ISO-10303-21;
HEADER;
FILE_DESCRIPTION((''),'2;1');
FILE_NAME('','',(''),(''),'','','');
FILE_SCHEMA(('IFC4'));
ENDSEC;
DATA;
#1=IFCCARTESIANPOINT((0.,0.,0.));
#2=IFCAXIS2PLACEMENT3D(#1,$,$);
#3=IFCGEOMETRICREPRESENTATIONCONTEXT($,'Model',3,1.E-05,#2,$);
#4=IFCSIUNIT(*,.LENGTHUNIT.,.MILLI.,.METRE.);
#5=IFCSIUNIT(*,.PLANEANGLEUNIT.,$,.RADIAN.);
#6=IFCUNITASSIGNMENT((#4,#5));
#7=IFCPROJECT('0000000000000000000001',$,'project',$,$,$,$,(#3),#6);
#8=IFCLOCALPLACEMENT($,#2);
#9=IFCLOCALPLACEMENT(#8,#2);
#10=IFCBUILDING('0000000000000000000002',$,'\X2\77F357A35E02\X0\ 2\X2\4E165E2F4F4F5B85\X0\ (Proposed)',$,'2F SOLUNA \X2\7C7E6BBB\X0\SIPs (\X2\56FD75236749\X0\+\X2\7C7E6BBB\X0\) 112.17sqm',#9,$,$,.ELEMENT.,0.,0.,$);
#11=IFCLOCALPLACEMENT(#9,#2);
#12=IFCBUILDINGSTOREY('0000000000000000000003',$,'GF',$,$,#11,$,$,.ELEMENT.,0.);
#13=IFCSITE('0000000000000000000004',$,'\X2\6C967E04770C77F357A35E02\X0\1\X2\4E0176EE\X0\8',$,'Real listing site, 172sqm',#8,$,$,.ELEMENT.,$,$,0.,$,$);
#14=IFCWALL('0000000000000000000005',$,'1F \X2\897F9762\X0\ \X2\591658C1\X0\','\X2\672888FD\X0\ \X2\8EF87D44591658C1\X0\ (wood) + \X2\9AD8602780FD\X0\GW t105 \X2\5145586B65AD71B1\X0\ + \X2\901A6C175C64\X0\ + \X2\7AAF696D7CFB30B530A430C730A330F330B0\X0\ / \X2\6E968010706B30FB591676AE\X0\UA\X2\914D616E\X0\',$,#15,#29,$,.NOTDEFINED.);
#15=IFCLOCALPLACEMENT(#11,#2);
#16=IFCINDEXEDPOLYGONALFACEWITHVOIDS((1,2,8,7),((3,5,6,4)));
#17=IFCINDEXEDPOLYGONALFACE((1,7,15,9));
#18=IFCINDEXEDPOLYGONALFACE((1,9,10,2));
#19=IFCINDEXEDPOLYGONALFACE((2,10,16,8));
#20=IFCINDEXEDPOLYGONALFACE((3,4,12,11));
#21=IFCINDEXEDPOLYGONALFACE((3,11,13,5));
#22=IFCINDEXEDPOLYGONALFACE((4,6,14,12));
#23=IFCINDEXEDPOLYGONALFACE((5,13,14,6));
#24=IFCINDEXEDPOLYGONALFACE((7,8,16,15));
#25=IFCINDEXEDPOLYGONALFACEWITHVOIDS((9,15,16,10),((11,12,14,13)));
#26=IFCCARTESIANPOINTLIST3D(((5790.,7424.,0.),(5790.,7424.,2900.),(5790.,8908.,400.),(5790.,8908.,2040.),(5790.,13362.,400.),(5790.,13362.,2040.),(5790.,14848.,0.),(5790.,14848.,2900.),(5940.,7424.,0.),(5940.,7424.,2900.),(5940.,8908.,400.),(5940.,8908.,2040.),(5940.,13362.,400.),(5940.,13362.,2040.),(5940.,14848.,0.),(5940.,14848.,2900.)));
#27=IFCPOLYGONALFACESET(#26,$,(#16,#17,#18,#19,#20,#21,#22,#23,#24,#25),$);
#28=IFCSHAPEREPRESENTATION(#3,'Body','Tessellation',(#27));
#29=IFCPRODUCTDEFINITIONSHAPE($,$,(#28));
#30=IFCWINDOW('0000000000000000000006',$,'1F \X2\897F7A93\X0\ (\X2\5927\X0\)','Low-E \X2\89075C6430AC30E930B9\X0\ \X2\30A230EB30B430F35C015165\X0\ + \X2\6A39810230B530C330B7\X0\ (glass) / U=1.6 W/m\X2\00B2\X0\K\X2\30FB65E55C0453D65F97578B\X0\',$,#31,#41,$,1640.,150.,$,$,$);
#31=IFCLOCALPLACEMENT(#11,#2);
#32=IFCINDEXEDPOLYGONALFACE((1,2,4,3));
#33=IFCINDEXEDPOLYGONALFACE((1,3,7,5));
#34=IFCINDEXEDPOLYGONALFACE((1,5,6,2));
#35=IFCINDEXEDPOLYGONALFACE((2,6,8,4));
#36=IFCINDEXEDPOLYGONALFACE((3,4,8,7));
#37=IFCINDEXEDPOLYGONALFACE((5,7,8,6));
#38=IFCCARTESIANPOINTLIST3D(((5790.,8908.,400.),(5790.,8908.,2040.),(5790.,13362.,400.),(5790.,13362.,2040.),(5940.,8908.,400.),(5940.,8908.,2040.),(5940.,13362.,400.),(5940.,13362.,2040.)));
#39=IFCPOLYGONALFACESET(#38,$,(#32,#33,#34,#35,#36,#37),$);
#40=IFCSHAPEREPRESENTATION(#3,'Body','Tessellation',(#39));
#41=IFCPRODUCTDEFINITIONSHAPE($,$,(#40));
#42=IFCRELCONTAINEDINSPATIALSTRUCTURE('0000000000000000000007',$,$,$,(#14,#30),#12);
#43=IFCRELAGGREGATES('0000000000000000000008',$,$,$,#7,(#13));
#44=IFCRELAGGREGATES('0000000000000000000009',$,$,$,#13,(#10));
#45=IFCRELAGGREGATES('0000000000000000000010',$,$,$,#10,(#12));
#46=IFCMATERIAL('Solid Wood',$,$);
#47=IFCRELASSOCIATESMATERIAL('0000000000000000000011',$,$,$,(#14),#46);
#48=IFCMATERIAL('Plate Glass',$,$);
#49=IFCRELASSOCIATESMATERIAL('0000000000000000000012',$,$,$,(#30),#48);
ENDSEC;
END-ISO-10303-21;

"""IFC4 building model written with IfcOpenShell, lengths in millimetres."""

from ifc_helpers import new_model, si_unit, frame, frame_2d, origin, place, context, project, spatial, rectangle, extrude, material, element, fill, save


model = new_model("IFC4")

# Units and contexts
model_context = context("Model", 3, precision=1e-05, world=origin())
ifc_project = project(units=[si_unit("LENGTHUNIT", "METRE", prefix="MILLI"), si_unit("PLANEANGLEUNIT", "RADIAN")], contexts=[model_context])

# Site, building, storey
site_placement = place(None, origin())
site = spatial("IfcSite", under=ifc_project, at=site_placement, Name="沖縄県石垣市1丁目8", ObjectType="Real listing site, 172sqm", CompositionType="ELEMENT", RefElevation=0.0)
building_placement = place(site_placement, origin())
building = spatial("IfcBuilding", under=site, at=building_placement, Name="石垣市 2世帯住宅 (Proposed)", ObjectType="2F SOLUNA 籾殻SIPs (国産杉+籾殻) 112.17sqm", CompositionType="ELEMENT", ElevationOfRefHeight=0.0, ElevationOfTerrain=0.0)
storey_placement = place(building_placement, origin())
storey = spatial("IfcBuildingStorey", under=building, at=storey_placement, Name="GF", CompositionType="ELEMENT", Elevation=0.0)

# Shared definitions
ifc_material_1 = material(Name="Solid Wood")

# Shared definitions
ifc_material_2 = material(Name="Plate Glass")

# Wall, opening, window
wall_1_placement = place(storey_placement, frame((2895.0, 3712.0, 0.0)))
wall_1 = element("IfcWall", 1, at=wall_1_placement, inside=storey, material=ifc_material_1, Name="1F 西面 外壁", Description="木製 軸組外壁 (wood) + 高性能GW t105 充填断熱 + 通気層 + 窯業系サイディング / 準耐火・外皮UA配慮", PredefinedType="NOTDEFINED", context=model_context, shape_type="SweptSolid", body=[
    extrude(rectangle(XDim=150.0, YDim=7424.0, at=frame_2d((75.0, 3712.0))), frame((2895.0, 3712.0, 0.0)), (0.0, 0.0, 1.0), 2900.0),
])
opening_1_placement = place(storey_placement, frame((2895.0, 4454.0, 200.0)))
opening_1 = element("IfcOpeningElement", 2, at=opening_1_placement, cuts=wall_1, PredefinedType="NOTDEFINED", context=model_context, shape_type="SweptSolid", body=[
    extrude(rectangle(XDim=150.0, YDim=4454.0, at=frame_2d((75.0, 2227.0))), frame((2895.0, 4454.0, 200.0)), (0.0, 0.0, 1.0), 1640.0),
])
window_1_placement = place(storey_placement, frame((2895.0, 4454.0, 200.0)))
window_1 = element("IfcWindow", 3, at=window_1_placement, inside=storey, material=ifc_material_2, Name="1F 西窓 (大)", Description="Low-E 複層ガラス アルゴン封入 + 樹脂サッシ (glass) / U=1.6 W/m²K・日射取得型", OverallHeight=1640.0, OverallWidth=150.0, context=model_context, shape_type="SweptSolid", body=[
    extrude(rectangle(XDim=150.0, YDim=4454.0, at=frame_2d((75.0, 2227.0))), frame((2895.0, 4454.0, 200.0)), (0.0, 0.0, 1.0), 1640.0),
])
fill(opening_1, window_1)

save(model, "model.ifc")
